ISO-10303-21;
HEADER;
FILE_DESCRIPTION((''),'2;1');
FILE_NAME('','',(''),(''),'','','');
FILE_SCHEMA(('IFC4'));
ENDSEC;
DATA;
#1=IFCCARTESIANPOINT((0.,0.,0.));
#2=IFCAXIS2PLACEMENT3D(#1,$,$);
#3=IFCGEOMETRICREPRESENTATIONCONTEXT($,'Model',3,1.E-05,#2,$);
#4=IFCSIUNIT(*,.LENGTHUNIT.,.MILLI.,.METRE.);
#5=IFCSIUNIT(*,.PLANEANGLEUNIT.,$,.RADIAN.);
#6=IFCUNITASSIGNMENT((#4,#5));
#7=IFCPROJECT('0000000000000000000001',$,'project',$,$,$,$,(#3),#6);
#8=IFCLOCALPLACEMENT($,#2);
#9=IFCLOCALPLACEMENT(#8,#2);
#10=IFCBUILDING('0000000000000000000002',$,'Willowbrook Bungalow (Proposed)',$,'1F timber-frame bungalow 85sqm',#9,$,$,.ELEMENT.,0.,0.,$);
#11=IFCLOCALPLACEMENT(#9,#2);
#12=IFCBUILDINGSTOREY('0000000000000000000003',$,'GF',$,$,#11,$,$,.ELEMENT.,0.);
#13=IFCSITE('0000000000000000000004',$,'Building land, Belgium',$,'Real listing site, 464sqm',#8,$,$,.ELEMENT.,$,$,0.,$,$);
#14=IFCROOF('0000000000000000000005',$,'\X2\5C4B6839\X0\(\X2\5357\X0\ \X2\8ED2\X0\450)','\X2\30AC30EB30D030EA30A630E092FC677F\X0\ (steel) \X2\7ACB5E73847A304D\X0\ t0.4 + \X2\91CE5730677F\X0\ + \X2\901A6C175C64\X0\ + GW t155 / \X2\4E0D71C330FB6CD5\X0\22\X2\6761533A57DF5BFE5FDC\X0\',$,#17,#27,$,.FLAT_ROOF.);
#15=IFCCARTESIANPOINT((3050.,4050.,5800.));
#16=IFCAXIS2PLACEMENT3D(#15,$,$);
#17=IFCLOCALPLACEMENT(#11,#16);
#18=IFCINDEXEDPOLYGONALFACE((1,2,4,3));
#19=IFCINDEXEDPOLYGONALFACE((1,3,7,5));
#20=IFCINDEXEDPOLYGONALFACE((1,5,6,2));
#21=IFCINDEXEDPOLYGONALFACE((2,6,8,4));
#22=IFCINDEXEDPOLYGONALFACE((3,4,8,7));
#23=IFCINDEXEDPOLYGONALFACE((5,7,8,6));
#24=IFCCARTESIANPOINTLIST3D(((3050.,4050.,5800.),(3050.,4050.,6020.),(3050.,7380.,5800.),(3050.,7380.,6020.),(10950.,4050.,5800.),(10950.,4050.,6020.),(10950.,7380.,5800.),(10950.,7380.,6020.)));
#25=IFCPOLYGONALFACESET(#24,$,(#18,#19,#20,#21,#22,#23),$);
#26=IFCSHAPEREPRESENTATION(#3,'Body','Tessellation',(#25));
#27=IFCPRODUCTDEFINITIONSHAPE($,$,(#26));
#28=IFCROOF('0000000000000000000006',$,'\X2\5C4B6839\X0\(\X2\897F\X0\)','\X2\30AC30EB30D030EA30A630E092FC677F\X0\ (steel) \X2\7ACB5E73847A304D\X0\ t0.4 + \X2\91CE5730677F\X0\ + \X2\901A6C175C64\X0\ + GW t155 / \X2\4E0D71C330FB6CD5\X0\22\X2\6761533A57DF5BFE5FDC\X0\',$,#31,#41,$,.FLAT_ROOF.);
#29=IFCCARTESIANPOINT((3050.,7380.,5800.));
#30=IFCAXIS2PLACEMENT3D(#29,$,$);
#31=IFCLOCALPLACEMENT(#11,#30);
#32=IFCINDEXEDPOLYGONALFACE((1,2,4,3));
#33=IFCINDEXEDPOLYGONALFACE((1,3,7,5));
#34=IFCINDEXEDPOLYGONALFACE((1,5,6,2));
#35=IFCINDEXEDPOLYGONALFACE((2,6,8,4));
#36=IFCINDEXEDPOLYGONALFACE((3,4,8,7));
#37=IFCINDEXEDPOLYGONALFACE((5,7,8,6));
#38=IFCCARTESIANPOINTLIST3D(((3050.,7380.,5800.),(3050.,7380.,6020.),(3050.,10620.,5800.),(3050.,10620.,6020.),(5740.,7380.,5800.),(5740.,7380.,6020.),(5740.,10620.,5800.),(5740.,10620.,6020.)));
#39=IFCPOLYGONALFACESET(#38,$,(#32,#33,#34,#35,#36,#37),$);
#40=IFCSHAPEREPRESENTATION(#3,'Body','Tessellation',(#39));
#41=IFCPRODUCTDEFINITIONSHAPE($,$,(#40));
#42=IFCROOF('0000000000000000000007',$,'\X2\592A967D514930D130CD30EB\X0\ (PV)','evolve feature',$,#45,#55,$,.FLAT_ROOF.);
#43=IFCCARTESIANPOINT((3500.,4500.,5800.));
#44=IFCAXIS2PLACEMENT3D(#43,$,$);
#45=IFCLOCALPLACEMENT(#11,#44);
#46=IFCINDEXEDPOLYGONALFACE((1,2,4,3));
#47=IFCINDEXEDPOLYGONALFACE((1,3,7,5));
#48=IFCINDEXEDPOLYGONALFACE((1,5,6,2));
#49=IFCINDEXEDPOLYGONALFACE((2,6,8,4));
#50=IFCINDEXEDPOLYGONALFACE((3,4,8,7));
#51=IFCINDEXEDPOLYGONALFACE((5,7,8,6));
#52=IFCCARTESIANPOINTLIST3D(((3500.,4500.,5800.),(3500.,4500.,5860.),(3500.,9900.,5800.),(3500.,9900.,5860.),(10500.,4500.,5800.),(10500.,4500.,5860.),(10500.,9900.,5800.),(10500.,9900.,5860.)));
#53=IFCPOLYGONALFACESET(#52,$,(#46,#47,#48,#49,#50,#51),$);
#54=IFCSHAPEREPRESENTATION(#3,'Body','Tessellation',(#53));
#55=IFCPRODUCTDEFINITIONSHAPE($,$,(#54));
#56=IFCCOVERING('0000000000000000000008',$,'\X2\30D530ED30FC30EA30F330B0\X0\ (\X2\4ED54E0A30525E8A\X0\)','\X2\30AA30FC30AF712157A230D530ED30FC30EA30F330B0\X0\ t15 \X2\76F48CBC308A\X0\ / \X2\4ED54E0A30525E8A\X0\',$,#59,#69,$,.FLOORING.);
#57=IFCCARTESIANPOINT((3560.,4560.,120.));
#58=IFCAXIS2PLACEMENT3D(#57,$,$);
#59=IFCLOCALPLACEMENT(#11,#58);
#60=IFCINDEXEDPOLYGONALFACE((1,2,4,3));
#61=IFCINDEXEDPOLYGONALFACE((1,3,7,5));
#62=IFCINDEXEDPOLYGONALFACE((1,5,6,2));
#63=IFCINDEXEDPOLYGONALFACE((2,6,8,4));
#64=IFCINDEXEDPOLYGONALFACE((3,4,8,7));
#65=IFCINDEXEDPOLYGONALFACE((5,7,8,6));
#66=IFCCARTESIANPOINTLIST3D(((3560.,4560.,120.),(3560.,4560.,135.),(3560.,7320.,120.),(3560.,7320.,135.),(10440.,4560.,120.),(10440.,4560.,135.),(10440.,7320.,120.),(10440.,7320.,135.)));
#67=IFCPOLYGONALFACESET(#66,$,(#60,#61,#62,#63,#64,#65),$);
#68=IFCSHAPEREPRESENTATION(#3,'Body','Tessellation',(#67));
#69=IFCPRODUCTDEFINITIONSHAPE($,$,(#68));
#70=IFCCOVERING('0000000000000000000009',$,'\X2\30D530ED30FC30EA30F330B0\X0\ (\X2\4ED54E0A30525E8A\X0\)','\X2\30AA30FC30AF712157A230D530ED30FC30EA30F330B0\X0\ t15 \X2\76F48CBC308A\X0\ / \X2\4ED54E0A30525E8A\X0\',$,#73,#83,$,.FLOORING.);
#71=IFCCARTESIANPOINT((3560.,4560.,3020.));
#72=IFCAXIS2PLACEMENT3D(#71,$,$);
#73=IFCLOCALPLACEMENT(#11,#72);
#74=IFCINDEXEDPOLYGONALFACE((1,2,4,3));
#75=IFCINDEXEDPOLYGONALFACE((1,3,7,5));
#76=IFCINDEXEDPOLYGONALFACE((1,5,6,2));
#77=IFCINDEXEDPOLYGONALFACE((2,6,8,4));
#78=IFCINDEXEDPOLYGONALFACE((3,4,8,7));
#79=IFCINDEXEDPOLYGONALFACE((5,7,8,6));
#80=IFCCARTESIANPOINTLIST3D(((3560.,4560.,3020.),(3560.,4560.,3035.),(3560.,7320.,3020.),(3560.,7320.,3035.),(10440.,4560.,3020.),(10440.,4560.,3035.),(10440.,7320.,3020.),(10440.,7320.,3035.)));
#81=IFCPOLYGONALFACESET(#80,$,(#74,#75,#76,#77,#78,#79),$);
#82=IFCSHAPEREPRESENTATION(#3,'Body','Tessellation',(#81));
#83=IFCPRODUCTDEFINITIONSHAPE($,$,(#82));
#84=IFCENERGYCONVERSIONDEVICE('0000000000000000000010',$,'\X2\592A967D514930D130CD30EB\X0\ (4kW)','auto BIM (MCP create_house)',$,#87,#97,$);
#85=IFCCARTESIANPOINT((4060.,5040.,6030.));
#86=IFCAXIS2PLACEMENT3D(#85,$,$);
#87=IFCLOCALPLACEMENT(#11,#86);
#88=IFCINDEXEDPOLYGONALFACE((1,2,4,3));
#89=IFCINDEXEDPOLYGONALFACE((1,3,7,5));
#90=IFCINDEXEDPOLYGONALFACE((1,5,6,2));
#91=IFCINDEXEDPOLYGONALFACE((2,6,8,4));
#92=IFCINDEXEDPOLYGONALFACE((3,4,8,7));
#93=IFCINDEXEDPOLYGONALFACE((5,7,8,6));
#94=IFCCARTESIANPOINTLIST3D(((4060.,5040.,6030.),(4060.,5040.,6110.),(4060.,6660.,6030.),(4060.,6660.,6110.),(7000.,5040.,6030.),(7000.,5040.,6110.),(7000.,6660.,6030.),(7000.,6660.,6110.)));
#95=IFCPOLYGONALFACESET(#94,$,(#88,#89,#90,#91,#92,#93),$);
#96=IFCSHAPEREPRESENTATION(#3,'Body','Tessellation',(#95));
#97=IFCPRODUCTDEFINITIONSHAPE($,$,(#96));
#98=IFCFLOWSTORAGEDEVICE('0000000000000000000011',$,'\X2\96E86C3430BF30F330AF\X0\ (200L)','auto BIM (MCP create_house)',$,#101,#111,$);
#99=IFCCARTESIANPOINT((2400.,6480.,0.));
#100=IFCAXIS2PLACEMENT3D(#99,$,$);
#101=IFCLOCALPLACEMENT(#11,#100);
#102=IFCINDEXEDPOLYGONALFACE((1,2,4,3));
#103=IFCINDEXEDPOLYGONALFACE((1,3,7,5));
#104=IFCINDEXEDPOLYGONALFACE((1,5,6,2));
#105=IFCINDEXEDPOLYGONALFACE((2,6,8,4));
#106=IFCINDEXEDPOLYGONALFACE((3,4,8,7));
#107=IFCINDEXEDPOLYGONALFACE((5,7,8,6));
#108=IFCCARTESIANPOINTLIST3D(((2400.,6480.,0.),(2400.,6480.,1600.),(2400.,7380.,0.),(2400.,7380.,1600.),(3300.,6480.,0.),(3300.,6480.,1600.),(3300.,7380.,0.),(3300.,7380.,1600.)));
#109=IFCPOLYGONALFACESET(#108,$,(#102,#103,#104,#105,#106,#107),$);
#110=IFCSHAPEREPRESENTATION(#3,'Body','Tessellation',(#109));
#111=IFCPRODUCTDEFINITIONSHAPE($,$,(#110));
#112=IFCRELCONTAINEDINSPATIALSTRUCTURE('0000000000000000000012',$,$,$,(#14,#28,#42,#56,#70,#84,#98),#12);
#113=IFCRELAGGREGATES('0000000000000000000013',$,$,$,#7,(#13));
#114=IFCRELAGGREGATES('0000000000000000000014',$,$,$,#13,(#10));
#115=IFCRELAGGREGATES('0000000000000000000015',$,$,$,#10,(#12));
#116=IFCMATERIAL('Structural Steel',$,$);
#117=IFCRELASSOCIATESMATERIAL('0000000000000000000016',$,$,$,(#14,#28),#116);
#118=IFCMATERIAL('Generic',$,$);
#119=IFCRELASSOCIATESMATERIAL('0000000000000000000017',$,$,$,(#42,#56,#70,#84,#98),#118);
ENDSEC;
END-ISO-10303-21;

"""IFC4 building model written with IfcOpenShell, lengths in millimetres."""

from ifc_helpers import new_model, si_unit, frame, frame_2d, origin, place, context, project, spatial, rectangle, extrude, material, element, save


model = new_model("IFC4")

# Units and contexts
model_context = context("Model", 3, precision=1e-05, world=origin())
ifc_project = project(units=[si_unit("LENGTHUNIT", "METRE", prefix="MILLI"), si_unit("PLANEANGLEUNIT", "RADIAN")], contexts=[model_context])

# Site, building, storey
site_placement = place(None, origin())
site = spatial("IfcSite", under=ifc_project, at=site_placement, Name="Building land, Belgium", ObjectType="Real listing site, 464sqm", CompositionType="ELEMENT", RefElevation=0.0)
building_placement = place(site_placement, origin())
building = spatial("IfcBuilding", under=site, at=building_placement, Name="Willowbrook Bungalow (Proposed)", ObjectType="1F timber-frame bungalow 85sqm", CompositionType="ELEMENT", ElevationOfRefHeight=0.0, ElevationOfTerrain=0.0)
storey_placement = place(building_placement, origin())
storey = spatial("IfcBuildingStorey", under=building, at=storey_placement, Name="GF", CompositionType="ELEMENT", Elevation=0.0)

# Shared definitions
ifc_material_1 = material(Name="Generic")

# Roofs
ifc_material_2 = material(Name="Structural Steel")
roof_1_placement = place(storey_placement, frame((3050.0, 4050.0, 5800.0)))
element("IfcRoof", 1, at=roof_1_placement, inside=storey, material=ifc_material_2, Name="屋根(南 軒450)", Description="ガルバリウム鋼板 (steel) 立平葺き t0.4 + 野地板 + 通気層 + GW t155 / 不燃・法22条区域対応", PredefinedType="FLAT_ROOF", context=model_context, shape_type="SweptSolid", body=[
    extrude(rectangle(XDim=7900.0, YDim=3330.0, at=frame_2d((3950.0, 1665.0))), frame((3050.0, 4050.0, 5800.0)), (0.0, 0.0, 1.0), 220.0),
])
roof_2_placement = place(storey_placement, frame((3050.0, 7380.0, 5800.0)))
element("IfcRoof", 2, at=roof_2_placement, inside=storey, material=ifc_material_2, Name="屋根(西)", Description="ガルバリウム鋼板 (steel) 立平葺き t0.4 + 野地板 + 通気層 + GW t155 / 不燃・法22条区域対応", PredefinedType="FLAT_ROOF", context=model_context, shape_type="SweptSolid", body=[
    extrude(rectangle(XDim=2690.0, YDim=3240.0, at=frame_2d((1345.0, 1620.0))), frame((3050.0, 7380.0, 5800.0)), (0.0, 0.0, 1.0), 220.0),
])
roof_3_placement = place(storey_placement, frame((3500.0, 4500.0, 5800.0)))
element("IfcRoof", 3, at=roof_3_placement, inside=storey, material=ifc_material_1, Name="太陽光パネル (PV)", Description="evolve feature", PredefinedType="FLAT_ROOF", context=model_context, shape_type="SweptSolid", body=[
    extrude(rectangle(XDim=7000.0, YDim=5400.0, at=frame_2d((3500.0, 2700.0))), frame((3500.0, 4500.0, 5800.0)), (0.0, 0.0, 1.0), 60.0),
])

# Coverings
covering_1_placement = place(storey_placement, frame((3560.0, 4560.0, 120.0)))
element("IfcCovering", 4, at=covering_1_placement, inside=storey, material=ifc_material_1, Name="フローリング (仕上げ床)", Description="オーク無垢フローリング t15 直貼り / 仕上げ床", PredefinedType="FLOORING", context=model_context, shape_type="SweptSolid", body=[
    extrude(rectangle(XDim=6880.0, YDim=2760.0, at=frame_2d((3440.0, 1380.0))), frame((3560.0, 4560.0, 120.0)), (0.0, 0.0, 1.0), 15.0),
])
covering_2_placement = place(storey_placement, frame((3560.0, 4560.0, 3020.0)))
element("IfcCovering", 5, at=covering_2_placement, inside=storey, material=ifc_material_1, Name="フローリング (仕上げ床)", Description="オーク無垢フローリング t15 直貼り / 仕上げ床", PredefinedType="FLOORING", context=model_context, shape_type="SweptSolid", body=[
    extrude(rectangle(XDim=6880.0, YDim=2760.0, at=frame_2d((3440.0, 1380.0))), frame((3560.0, 4560.0, 3020.0)), (0.0, 0.0, 1.0), 15.0),
])

# Energy conversion device
energy_conversion_device_placement = place(storey_placement, frame((4060.0, 5040.0, 6030.0)))
element("IfcEnergyConversionDevice", 6, at=energy_conversion_device_placement, inside=storey, material=ifc_material_1, Name="太陽光パネル (4kW)", Description="auto BIM (MCP create_house)", context=model_context, shape_type="SweptSolid", body=[
    extrude(rectangle(XDim=2940.0, YDim=1620.0, at=frame_2d((1470.0, 810.0))), frame((4060.0, 5040.0, 6030.0)), (0.0, 0.0, 1.0), 80.0),
])

# Flow storage device
flow_storage_device_placement = place(storey_placement, frame((2400.0, 6480.0, 0.0)))
element("IfcFlowStorageDevice", 7, at=flow_storage_device_placement, inside=storey, material=ifc_material_1, Name="雨水タンク (200L)", Description="auto BIM (MCP create_house)", context=model_context, shape_type="SweptSolid", body=[
    extrude(rectangle(XDim=900.0, YDim=900.0, at=frame_2d((450.0, 450.0))), frame((2400.0, 6480.0, 0.0)), (0.0, 0.0, 1.0), 1600.0),
])

save(model, "model.ifc")
